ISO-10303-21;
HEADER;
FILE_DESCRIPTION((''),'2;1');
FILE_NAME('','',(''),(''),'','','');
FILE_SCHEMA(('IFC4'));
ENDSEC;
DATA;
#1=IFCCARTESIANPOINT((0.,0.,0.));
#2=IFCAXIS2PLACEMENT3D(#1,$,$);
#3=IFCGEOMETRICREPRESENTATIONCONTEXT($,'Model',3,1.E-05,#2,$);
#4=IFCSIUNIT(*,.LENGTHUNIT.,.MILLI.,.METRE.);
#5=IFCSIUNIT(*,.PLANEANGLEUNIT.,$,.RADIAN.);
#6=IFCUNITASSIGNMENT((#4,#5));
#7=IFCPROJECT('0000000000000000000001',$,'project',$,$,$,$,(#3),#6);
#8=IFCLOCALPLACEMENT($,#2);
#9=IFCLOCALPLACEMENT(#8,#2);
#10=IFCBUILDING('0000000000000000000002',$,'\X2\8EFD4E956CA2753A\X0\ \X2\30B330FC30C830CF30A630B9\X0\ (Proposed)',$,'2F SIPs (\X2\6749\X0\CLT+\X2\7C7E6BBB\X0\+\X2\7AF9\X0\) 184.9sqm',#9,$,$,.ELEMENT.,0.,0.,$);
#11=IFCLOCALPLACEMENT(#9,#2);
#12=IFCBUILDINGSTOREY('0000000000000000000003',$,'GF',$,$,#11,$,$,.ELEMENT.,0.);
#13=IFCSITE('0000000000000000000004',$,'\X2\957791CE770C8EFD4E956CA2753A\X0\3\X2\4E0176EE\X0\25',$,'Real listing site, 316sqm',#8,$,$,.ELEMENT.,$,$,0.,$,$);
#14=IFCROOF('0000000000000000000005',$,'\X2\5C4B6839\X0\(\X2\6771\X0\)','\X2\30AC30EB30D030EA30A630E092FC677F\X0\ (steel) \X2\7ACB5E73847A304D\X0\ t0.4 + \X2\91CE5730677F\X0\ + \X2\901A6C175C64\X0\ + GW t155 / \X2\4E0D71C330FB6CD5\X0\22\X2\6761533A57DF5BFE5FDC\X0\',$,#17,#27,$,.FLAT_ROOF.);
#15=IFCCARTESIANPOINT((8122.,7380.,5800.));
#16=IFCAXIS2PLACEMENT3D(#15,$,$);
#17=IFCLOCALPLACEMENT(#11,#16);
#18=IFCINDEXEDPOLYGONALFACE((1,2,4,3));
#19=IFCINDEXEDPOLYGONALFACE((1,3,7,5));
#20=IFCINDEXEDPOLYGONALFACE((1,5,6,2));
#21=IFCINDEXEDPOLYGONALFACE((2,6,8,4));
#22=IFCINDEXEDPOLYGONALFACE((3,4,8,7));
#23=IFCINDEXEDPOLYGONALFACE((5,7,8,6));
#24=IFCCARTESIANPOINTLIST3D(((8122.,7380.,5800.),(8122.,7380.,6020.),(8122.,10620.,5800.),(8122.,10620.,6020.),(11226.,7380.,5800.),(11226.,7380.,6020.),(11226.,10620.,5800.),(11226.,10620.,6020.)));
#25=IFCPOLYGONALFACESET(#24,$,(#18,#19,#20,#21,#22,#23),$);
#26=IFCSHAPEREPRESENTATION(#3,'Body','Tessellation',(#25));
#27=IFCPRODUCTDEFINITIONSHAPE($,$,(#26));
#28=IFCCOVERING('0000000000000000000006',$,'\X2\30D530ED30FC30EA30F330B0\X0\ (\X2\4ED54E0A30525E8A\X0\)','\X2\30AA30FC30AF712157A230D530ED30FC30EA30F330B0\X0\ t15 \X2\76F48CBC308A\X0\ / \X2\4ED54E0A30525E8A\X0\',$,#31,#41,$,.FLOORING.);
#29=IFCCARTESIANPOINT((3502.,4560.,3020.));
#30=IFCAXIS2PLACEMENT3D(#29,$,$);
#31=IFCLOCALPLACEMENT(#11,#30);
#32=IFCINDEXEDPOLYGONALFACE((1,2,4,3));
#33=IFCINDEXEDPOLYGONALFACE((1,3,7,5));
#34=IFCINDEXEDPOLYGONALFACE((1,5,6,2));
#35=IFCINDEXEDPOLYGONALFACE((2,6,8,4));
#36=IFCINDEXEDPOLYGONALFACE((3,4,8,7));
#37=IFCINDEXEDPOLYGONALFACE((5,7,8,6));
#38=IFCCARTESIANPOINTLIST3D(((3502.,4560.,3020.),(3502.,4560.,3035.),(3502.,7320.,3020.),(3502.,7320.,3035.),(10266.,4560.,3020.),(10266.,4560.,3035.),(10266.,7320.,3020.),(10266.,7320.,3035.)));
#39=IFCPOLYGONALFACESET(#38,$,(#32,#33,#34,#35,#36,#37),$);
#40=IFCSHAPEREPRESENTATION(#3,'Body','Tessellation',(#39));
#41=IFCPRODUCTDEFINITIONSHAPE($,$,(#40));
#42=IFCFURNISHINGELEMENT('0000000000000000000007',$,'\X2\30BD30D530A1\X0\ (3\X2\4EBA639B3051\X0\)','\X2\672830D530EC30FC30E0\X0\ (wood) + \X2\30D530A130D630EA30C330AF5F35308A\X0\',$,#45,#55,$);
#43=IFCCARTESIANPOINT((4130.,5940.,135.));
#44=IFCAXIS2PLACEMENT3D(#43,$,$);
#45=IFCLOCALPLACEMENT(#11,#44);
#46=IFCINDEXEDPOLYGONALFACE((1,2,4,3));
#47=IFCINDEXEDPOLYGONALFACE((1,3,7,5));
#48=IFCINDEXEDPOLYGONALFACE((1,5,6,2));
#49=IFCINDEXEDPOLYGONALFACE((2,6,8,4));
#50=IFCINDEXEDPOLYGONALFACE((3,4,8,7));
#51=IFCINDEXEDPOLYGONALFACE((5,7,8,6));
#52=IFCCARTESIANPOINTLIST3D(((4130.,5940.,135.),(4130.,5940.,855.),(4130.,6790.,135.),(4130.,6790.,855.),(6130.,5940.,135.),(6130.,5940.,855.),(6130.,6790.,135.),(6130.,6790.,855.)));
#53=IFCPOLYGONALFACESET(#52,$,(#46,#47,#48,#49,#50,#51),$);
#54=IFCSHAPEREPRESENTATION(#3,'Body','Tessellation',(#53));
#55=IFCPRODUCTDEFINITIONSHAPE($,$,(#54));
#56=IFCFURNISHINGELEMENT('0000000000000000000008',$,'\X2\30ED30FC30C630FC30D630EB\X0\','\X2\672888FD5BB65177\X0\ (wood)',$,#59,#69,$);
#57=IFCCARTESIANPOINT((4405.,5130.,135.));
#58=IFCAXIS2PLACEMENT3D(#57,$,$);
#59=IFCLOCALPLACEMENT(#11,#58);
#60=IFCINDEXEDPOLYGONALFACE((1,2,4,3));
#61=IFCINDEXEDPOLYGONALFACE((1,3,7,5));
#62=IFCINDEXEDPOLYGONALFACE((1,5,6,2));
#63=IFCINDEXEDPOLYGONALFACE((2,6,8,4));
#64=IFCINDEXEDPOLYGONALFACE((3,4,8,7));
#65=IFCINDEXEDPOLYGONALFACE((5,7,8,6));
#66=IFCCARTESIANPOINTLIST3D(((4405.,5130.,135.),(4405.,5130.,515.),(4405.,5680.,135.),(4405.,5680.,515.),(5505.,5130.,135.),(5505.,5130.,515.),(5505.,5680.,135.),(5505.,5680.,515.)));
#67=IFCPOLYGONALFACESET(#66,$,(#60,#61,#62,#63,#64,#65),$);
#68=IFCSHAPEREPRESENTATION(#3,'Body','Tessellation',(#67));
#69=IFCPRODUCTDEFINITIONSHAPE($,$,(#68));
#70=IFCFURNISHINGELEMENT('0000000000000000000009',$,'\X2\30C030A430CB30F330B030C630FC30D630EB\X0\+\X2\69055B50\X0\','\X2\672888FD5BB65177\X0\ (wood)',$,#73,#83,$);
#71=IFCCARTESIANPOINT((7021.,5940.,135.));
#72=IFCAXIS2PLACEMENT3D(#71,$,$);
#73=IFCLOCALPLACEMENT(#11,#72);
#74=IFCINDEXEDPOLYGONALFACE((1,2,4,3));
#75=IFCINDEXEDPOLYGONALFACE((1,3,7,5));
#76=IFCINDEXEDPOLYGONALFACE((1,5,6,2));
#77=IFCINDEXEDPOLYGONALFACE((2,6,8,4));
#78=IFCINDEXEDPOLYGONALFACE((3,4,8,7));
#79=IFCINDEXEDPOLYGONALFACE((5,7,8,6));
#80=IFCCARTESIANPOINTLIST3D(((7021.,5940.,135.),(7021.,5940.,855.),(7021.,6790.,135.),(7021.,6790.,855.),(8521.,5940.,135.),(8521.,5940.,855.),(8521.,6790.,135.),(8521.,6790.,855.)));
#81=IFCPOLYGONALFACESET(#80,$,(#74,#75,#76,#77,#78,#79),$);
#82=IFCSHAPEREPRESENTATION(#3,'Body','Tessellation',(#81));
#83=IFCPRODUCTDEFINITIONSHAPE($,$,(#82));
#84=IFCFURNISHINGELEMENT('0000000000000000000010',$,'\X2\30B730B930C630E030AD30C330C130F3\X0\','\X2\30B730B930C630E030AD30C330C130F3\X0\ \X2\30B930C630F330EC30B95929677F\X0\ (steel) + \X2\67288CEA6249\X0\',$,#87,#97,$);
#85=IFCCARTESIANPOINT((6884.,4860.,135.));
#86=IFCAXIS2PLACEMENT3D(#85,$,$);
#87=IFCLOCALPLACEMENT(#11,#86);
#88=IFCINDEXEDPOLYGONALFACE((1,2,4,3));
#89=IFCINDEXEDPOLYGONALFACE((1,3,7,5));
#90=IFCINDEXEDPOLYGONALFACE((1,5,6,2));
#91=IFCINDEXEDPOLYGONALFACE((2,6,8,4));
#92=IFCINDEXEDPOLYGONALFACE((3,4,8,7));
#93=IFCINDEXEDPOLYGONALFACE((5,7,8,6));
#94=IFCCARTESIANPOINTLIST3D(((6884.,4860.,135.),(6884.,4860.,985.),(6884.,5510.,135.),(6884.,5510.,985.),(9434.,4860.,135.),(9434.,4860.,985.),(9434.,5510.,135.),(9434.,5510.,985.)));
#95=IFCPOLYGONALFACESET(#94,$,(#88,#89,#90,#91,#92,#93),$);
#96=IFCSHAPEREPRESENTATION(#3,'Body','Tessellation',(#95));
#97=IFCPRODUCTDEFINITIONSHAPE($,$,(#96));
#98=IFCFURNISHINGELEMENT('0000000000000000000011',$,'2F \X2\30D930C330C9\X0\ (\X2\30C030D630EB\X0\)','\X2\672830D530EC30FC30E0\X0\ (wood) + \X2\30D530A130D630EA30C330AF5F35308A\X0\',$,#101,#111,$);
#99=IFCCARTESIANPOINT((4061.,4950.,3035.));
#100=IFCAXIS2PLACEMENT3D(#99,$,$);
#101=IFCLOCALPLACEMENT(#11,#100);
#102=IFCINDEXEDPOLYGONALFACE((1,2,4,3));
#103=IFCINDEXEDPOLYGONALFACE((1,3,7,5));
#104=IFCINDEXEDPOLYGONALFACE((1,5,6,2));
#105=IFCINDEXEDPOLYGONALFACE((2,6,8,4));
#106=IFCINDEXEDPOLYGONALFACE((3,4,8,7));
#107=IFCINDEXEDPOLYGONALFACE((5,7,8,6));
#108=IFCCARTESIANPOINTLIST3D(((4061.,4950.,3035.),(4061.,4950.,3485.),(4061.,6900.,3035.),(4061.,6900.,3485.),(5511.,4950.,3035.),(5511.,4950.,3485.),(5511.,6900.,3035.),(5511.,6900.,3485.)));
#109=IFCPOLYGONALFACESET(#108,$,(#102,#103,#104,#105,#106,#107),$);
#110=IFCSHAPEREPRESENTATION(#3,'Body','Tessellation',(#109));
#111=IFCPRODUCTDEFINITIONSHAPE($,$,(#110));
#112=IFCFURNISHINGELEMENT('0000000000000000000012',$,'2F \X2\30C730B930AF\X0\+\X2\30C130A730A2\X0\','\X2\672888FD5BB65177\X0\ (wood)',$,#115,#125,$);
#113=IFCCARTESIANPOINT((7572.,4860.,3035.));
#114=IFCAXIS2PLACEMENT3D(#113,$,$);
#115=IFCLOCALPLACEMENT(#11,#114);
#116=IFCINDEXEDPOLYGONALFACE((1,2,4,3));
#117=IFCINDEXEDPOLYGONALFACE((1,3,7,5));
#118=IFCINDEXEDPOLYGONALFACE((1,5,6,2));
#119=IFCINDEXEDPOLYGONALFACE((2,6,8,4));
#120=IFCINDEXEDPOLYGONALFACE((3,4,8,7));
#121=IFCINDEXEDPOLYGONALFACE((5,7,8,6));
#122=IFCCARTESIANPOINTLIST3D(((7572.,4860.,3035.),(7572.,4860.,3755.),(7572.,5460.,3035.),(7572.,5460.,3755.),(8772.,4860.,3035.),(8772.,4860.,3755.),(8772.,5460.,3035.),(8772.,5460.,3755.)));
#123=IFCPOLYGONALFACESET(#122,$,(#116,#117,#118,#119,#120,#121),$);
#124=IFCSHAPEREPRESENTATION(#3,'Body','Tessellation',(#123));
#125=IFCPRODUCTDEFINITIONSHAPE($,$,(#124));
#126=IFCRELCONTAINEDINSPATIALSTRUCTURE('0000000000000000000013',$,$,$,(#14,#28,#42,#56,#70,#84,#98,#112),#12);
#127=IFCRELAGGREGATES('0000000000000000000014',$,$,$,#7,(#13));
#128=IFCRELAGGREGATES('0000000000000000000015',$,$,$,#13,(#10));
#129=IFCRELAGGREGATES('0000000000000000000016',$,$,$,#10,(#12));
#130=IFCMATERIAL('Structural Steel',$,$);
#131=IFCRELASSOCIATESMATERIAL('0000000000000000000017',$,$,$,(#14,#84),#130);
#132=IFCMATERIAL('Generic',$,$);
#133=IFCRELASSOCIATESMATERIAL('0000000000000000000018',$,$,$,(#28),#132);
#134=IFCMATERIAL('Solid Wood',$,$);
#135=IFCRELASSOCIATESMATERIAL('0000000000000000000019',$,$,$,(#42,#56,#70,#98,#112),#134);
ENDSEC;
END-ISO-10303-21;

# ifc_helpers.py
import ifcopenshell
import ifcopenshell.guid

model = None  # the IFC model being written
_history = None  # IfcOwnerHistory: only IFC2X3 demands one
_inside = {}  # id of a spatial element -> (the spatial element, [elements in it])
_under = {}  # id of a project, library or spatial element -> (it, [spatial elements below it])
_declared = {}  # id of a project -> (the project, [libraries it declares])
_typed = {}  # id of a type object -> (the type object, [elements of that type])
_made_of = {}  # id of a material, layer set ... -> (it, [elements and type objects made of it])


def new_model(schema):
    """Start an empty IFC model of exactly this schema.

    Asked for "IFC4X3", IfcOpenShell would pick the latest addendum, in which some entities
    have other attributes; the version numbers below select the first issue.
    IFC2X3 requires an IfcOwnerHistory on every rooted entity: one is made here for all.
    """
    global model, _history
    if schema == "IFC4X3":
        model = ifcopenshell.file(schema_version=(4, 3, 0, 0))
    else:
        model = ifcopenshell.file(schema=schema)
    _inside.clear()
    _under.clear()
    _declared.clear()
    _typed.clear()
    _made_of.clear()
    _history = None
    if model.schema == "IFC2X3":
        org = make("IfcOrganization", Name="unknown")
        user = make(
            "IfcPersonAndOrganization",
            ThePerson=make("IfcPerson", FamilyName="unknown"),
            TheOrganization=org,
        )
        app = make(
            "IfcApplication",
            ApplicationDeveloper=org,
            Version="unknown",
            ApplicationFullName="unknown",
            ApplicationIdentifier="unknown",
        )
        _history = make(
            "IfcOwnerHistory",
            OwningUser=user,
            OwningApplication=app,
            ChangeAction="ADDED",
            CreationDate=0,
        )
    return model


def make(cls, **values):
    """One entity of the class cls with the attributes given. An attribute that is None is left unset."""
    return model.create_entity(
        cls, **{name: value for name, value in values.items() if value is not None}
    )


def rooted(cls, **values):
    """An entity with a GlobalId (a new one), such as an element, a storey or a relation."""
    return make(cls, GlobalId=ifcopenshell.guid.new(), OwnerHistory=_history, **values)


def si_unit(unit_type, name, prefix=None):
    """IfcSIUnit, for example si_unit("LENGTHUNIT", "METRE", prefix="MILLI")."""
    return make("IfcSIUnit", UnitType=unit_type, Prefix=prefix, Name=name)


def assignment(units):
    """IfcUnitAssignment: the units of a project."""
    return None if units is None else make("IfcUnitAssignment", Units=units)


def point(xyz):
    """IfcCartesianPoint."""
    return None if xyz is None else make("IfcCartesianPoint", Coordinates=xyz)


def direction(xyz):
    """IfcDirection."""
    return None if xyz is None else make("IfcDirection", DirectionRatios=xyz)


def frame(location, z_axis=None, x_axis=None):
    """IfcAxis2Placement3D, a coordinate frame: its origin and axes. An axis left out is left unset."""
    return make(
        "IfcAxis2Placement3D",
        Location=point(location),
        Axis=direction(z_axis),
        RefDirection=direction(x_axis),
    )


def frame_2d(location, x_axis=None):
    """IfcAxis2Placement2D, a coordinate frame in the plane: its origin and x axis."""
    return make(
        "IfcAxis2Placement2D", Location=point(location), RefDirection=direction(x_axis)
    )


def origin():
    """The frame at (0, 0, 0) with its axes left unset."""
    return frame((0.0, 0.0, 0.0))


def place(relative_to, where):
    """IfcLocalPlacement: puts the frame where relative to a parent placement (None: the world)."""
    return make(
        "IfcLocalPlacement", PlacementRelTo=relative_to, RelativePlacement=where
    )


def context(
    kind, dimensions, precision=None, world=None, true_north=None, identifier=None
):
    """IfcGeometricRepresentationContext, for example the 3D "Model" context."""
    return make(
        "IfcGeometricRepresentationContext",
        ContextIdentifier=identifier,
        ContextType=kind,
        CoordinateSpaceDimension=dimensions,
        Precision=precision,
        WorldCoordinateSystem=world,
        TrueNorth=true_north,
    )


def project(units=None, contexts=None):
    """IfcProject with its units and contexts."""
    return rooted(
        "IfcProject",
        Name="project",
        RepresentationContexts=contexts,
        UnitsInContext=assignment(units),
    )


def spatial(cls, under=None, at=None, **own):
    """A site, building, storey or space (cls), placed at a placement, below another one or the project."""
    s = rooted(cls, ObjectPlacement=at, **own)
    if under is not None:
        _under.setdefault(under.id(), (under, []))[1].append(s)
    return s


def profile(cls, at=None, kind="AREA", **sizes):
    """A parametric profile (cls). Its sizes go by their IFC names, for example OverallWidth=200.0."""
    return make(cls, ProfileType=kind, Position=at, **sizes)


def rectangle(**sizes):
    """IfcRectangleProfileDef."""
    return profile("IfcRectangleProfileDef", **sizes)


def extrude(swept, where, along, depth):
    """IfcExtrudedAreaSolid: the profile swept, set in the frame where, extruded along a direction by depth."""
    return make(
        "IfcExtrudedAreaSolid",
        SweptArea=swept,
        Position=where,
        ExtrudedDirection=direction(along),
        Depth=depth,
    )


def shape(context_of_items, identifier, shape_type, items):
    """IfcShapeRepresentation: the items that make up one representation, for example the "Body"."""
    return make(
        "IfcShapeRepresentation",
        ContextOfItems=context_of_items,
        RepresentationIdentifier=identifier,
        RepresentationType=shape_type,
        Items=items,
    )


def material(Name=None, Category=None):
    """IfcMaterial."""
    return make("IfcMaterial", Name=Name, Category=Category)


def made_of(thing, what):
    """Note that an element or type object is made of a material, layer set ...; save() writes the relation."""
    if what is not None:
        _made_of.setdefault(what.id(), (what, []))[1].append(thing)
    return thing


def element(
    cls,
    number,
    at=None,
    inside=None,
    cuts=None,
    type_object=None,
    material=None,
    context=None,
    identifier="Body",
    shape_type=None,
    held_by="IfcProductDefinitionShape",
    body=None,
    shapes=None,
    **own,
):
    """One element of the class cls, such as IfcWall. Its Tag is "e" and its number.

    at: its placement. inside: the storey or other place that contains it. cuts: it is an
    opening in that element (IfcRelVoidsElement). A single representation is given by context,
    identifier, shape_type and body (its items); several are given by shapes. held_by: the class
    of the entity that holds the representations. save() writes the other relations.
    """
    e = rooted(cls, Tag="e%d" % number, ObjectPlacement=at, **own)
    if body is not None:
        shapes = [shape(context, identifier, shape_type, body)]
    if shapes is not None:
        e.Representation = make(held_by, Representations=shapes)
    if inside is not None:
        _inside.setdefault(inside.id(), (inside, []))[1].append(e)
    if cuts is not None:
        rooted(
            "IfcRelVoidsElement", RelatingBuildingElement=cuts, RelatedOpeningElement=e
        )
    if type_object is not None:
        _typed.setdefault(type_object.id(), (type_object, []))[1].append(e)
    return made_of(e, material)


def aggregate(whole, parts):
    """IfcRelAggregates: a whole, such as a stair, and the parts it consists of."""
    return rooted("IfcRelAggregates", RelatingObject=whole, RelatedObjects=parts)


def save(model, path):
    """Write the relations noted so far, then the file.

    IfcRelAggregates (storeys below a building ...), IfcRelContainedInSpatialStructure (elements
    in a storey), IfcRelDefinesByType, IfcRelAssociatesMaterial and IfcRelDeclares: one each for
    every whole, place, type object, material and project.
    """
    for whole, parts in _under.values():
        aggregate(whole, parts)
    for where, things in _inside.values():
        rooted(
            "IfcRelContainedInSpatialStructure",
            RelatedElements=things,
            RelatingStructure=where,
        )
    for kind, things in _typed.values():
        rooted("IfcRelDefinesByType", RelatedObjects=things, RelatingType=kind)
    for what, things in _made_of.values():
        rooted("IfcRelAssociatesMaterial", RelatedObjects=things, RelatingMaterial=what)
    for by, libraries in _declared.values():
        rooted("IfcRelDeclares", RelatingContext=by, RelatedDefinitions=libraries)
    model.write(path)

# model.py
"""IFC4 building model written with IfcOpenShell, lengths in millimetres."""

from ifc_helpers import new_model, si_unit, frame, frame_2d, origin, place, context, project, spatial, rectangle, extrude, material, element, save


model = new_model("IFC4")

# Units and contexts
model_context = context("Model", 3, precision=1e-05, world=origin())
ifc_project = project(units=[si_unit("LENGTHUNIT", "METRE", prefix="MILLI"), si_unit("PLANEANGLEUNIT", "RADIAN")], contexts=[model_context])

# Site, building, storey
site_placement = place(None, origin())
site = spatial("IfcSite", under=ifc_project, at=site_placement, Name="長野県軽井沢町3丁目25", ObjectType="Real listing site, 316sqm", CompositionType="ELEMENT", RefElevation=0.0)
building_placement = place(site_placement, origin())
building = spatial("IfcBuilding", under=site, at=building_placement, Name="軽井沢町 コートハウス (Proposed)", ObjectType="2F SIPs (杉CLT+籾殻+竹) 184.9sqm", CompositionType="ELEMENT", ElevationOfRefHeight=0.0, ElevationOfTerrain=0.0)
storey_placement = place(building_placement, origin())
storey = spatial("IfcBuildingStorey", under=building, at=storey_placement, Name="GF", CompositionType="ELEMENT", Elevation=0.0)

# Shared definitions
ifc_material_1 = material(Name="Solid Wood")

# Shared definitions
ifc_material_2 = material(Name="Generic")

# Roof
ifc_material_3 = material(Name="Structural Steel")
roof_placement = place(storey_placement, frame((8122.0, 7380.0, 5800.0)))
element("IfcRoof", 1, at=roof_placement, inside=storey, material=ifc_material_3, Name="屋根(東)", Description="ガルバリウム鋼板 (steel) 立平葺き t0.4 + 野地板 + 通気層 + GW t155 / 不燃・法22条区域対応", PredefinedType="FLAT_ROOF", context=model_context, shape_type="SweptSolid", body=[
    extrude(rectangle(XDim=3104.0, YDim=3240.0, at=frame_2d((1552.0, 1620.0))), frame((8122.0, 7380.0, 5800.0)), (0.0, 0.0, 1.0), 220.0),
])

# Covering
covering_placement = place(storey_placement, frame((3502.0, 4560.0, 3020.0)))
element("IfcCovering", 2, at=covering_placement, inside=storey, material=ifc_material_2, Name="フローリング (仕上げ床)", Description="オーク無垢フローリング t15 直貼り / 仕上げ床", PredefinedType="FLOORING", context=model_context, shape_type="SweptSolid", body=[
    extrude(rectangle(XDim=6764.0, YDim=2760.0, at=frame_2d((3382.0, 1380.0))), frame((3502.0, 4560.0, 3020.0)), (0.0, 0.0, 1.0), 15.0),
])

# Furnishing elements
furnishing_1_placement = place(storey_placement, frame((4130.0, 5940.0, 135.0)))
element("IfcFurnishingElement", 3, at=furnishing_1_placement, inside=storey, material=ifc_material_1, Name="ソファ (3人掛け)", Description="木フレーム (wood) + ファブリック張り", context=model_context, shape_type="SweptSolid", body=[
    extrude(rectangle(XDim=2000.0, YDim=850.0, at=frame_2d((1000.0, 425.0))), frame((4130.0, 5940.0, 135.0)), (0.0, 0.0, 1.0), 720.0),
])
furnishing_2_placement = place(storey_placement, frame((4405.0, 5130.0, 135.0)))
element("IfcFurnishingElement", 4, at=furnishing_2_placement, inside=storey, material=ifc_material_1, Name="ローテーブル", Description="木製家具 (wood)", context=model_context, shape_type="SweptSolid", body=[
    extrude(rectangle(XDim=1100.0, YDim=550.0, at=frame_2d((550.0, 275.0))), frame((4405.0, 5130.0, 135.0)), (0.0, 0.0, 1.0), 380.0),
])
furnishing_3_placement = place(storey_placement, frame((7021.0, 5940.0, 135.0)))
element("IfcFurnishingElement", 5, at=furnishing_3_placement, inside=storey, material=ifc_material_1, Name="ダイニングテーブル+椅子", Description="木製家具 (wood)", context=model_context, shape_type="SweptSolid", body=[
    extrude(rectangle(XDim=1500.0, YDim=850.0, at=frame_2d((750.0, 425.0))), frame((7021.0, 5940.0, 135.0)), (0.0, 0.0, 1.0), 720.0),
])
furnishing_4_placement = place(storey_placement, frame((6884.0, 4860.0, 135.0)))
element("IfcFurnishingElement", 6, at=furnishing_4_placement, inside=storey, material=ifc_material_3, Name="システムキッチン", Description="システムキッチン ステンレス天板 (steel) + 木質扉", context=model_context, shape_type="SweptSolid", body=[
    extrude(rectangle(XDim=2550.0, YDim=650.0, at=frame_2d((1275.0, 325.0))), frame((6884.0, 4860.0, 135.0)), (0.0, 0.0, 1.0), 850.0),
])
furnishing_5_placement = place(storey_placement, frame((4061.0, 4950.0, 3035.0)))
element("IfcFurnishingElement", 7, at=furnishing_5_placement, inside=storey, material=ifc_material_1, Name="2F ベッド (ダブル)", Description="木フレーム (wood) + ファブリック張り", context=model_context, shape_type="SweptSolid", body=[
    extrude(rectangle(XDim=1450.0, YDim=1950.0, at=frame_2d((725.0, 975.0))), frame((4061.0, 4950.0, 3035.0)), (0.0, 0.0, 1.0), 450.0),
])
furnishing_6_placement = place(storey_placement, frame((7572.0, 4860.0, 3035.0)))
element("IfcFurnishingElement", 8, at=furnishing_6_placement, inside=storey, material=ifc_material_1, Name="2F デスク+チェア", Description="木製家具 (wood)", context=model_context, shape_type="SweptSolid", body=[
    extrude(rectangle(XDim=1200.0, YDim=600.0, at=frame_2d((600.0, 300.0))), frame((7572.0, 4860.0, 3035.0)), (0.0, 0.0, 1.0), 720.0),
])

save(model, "model.ifc")
